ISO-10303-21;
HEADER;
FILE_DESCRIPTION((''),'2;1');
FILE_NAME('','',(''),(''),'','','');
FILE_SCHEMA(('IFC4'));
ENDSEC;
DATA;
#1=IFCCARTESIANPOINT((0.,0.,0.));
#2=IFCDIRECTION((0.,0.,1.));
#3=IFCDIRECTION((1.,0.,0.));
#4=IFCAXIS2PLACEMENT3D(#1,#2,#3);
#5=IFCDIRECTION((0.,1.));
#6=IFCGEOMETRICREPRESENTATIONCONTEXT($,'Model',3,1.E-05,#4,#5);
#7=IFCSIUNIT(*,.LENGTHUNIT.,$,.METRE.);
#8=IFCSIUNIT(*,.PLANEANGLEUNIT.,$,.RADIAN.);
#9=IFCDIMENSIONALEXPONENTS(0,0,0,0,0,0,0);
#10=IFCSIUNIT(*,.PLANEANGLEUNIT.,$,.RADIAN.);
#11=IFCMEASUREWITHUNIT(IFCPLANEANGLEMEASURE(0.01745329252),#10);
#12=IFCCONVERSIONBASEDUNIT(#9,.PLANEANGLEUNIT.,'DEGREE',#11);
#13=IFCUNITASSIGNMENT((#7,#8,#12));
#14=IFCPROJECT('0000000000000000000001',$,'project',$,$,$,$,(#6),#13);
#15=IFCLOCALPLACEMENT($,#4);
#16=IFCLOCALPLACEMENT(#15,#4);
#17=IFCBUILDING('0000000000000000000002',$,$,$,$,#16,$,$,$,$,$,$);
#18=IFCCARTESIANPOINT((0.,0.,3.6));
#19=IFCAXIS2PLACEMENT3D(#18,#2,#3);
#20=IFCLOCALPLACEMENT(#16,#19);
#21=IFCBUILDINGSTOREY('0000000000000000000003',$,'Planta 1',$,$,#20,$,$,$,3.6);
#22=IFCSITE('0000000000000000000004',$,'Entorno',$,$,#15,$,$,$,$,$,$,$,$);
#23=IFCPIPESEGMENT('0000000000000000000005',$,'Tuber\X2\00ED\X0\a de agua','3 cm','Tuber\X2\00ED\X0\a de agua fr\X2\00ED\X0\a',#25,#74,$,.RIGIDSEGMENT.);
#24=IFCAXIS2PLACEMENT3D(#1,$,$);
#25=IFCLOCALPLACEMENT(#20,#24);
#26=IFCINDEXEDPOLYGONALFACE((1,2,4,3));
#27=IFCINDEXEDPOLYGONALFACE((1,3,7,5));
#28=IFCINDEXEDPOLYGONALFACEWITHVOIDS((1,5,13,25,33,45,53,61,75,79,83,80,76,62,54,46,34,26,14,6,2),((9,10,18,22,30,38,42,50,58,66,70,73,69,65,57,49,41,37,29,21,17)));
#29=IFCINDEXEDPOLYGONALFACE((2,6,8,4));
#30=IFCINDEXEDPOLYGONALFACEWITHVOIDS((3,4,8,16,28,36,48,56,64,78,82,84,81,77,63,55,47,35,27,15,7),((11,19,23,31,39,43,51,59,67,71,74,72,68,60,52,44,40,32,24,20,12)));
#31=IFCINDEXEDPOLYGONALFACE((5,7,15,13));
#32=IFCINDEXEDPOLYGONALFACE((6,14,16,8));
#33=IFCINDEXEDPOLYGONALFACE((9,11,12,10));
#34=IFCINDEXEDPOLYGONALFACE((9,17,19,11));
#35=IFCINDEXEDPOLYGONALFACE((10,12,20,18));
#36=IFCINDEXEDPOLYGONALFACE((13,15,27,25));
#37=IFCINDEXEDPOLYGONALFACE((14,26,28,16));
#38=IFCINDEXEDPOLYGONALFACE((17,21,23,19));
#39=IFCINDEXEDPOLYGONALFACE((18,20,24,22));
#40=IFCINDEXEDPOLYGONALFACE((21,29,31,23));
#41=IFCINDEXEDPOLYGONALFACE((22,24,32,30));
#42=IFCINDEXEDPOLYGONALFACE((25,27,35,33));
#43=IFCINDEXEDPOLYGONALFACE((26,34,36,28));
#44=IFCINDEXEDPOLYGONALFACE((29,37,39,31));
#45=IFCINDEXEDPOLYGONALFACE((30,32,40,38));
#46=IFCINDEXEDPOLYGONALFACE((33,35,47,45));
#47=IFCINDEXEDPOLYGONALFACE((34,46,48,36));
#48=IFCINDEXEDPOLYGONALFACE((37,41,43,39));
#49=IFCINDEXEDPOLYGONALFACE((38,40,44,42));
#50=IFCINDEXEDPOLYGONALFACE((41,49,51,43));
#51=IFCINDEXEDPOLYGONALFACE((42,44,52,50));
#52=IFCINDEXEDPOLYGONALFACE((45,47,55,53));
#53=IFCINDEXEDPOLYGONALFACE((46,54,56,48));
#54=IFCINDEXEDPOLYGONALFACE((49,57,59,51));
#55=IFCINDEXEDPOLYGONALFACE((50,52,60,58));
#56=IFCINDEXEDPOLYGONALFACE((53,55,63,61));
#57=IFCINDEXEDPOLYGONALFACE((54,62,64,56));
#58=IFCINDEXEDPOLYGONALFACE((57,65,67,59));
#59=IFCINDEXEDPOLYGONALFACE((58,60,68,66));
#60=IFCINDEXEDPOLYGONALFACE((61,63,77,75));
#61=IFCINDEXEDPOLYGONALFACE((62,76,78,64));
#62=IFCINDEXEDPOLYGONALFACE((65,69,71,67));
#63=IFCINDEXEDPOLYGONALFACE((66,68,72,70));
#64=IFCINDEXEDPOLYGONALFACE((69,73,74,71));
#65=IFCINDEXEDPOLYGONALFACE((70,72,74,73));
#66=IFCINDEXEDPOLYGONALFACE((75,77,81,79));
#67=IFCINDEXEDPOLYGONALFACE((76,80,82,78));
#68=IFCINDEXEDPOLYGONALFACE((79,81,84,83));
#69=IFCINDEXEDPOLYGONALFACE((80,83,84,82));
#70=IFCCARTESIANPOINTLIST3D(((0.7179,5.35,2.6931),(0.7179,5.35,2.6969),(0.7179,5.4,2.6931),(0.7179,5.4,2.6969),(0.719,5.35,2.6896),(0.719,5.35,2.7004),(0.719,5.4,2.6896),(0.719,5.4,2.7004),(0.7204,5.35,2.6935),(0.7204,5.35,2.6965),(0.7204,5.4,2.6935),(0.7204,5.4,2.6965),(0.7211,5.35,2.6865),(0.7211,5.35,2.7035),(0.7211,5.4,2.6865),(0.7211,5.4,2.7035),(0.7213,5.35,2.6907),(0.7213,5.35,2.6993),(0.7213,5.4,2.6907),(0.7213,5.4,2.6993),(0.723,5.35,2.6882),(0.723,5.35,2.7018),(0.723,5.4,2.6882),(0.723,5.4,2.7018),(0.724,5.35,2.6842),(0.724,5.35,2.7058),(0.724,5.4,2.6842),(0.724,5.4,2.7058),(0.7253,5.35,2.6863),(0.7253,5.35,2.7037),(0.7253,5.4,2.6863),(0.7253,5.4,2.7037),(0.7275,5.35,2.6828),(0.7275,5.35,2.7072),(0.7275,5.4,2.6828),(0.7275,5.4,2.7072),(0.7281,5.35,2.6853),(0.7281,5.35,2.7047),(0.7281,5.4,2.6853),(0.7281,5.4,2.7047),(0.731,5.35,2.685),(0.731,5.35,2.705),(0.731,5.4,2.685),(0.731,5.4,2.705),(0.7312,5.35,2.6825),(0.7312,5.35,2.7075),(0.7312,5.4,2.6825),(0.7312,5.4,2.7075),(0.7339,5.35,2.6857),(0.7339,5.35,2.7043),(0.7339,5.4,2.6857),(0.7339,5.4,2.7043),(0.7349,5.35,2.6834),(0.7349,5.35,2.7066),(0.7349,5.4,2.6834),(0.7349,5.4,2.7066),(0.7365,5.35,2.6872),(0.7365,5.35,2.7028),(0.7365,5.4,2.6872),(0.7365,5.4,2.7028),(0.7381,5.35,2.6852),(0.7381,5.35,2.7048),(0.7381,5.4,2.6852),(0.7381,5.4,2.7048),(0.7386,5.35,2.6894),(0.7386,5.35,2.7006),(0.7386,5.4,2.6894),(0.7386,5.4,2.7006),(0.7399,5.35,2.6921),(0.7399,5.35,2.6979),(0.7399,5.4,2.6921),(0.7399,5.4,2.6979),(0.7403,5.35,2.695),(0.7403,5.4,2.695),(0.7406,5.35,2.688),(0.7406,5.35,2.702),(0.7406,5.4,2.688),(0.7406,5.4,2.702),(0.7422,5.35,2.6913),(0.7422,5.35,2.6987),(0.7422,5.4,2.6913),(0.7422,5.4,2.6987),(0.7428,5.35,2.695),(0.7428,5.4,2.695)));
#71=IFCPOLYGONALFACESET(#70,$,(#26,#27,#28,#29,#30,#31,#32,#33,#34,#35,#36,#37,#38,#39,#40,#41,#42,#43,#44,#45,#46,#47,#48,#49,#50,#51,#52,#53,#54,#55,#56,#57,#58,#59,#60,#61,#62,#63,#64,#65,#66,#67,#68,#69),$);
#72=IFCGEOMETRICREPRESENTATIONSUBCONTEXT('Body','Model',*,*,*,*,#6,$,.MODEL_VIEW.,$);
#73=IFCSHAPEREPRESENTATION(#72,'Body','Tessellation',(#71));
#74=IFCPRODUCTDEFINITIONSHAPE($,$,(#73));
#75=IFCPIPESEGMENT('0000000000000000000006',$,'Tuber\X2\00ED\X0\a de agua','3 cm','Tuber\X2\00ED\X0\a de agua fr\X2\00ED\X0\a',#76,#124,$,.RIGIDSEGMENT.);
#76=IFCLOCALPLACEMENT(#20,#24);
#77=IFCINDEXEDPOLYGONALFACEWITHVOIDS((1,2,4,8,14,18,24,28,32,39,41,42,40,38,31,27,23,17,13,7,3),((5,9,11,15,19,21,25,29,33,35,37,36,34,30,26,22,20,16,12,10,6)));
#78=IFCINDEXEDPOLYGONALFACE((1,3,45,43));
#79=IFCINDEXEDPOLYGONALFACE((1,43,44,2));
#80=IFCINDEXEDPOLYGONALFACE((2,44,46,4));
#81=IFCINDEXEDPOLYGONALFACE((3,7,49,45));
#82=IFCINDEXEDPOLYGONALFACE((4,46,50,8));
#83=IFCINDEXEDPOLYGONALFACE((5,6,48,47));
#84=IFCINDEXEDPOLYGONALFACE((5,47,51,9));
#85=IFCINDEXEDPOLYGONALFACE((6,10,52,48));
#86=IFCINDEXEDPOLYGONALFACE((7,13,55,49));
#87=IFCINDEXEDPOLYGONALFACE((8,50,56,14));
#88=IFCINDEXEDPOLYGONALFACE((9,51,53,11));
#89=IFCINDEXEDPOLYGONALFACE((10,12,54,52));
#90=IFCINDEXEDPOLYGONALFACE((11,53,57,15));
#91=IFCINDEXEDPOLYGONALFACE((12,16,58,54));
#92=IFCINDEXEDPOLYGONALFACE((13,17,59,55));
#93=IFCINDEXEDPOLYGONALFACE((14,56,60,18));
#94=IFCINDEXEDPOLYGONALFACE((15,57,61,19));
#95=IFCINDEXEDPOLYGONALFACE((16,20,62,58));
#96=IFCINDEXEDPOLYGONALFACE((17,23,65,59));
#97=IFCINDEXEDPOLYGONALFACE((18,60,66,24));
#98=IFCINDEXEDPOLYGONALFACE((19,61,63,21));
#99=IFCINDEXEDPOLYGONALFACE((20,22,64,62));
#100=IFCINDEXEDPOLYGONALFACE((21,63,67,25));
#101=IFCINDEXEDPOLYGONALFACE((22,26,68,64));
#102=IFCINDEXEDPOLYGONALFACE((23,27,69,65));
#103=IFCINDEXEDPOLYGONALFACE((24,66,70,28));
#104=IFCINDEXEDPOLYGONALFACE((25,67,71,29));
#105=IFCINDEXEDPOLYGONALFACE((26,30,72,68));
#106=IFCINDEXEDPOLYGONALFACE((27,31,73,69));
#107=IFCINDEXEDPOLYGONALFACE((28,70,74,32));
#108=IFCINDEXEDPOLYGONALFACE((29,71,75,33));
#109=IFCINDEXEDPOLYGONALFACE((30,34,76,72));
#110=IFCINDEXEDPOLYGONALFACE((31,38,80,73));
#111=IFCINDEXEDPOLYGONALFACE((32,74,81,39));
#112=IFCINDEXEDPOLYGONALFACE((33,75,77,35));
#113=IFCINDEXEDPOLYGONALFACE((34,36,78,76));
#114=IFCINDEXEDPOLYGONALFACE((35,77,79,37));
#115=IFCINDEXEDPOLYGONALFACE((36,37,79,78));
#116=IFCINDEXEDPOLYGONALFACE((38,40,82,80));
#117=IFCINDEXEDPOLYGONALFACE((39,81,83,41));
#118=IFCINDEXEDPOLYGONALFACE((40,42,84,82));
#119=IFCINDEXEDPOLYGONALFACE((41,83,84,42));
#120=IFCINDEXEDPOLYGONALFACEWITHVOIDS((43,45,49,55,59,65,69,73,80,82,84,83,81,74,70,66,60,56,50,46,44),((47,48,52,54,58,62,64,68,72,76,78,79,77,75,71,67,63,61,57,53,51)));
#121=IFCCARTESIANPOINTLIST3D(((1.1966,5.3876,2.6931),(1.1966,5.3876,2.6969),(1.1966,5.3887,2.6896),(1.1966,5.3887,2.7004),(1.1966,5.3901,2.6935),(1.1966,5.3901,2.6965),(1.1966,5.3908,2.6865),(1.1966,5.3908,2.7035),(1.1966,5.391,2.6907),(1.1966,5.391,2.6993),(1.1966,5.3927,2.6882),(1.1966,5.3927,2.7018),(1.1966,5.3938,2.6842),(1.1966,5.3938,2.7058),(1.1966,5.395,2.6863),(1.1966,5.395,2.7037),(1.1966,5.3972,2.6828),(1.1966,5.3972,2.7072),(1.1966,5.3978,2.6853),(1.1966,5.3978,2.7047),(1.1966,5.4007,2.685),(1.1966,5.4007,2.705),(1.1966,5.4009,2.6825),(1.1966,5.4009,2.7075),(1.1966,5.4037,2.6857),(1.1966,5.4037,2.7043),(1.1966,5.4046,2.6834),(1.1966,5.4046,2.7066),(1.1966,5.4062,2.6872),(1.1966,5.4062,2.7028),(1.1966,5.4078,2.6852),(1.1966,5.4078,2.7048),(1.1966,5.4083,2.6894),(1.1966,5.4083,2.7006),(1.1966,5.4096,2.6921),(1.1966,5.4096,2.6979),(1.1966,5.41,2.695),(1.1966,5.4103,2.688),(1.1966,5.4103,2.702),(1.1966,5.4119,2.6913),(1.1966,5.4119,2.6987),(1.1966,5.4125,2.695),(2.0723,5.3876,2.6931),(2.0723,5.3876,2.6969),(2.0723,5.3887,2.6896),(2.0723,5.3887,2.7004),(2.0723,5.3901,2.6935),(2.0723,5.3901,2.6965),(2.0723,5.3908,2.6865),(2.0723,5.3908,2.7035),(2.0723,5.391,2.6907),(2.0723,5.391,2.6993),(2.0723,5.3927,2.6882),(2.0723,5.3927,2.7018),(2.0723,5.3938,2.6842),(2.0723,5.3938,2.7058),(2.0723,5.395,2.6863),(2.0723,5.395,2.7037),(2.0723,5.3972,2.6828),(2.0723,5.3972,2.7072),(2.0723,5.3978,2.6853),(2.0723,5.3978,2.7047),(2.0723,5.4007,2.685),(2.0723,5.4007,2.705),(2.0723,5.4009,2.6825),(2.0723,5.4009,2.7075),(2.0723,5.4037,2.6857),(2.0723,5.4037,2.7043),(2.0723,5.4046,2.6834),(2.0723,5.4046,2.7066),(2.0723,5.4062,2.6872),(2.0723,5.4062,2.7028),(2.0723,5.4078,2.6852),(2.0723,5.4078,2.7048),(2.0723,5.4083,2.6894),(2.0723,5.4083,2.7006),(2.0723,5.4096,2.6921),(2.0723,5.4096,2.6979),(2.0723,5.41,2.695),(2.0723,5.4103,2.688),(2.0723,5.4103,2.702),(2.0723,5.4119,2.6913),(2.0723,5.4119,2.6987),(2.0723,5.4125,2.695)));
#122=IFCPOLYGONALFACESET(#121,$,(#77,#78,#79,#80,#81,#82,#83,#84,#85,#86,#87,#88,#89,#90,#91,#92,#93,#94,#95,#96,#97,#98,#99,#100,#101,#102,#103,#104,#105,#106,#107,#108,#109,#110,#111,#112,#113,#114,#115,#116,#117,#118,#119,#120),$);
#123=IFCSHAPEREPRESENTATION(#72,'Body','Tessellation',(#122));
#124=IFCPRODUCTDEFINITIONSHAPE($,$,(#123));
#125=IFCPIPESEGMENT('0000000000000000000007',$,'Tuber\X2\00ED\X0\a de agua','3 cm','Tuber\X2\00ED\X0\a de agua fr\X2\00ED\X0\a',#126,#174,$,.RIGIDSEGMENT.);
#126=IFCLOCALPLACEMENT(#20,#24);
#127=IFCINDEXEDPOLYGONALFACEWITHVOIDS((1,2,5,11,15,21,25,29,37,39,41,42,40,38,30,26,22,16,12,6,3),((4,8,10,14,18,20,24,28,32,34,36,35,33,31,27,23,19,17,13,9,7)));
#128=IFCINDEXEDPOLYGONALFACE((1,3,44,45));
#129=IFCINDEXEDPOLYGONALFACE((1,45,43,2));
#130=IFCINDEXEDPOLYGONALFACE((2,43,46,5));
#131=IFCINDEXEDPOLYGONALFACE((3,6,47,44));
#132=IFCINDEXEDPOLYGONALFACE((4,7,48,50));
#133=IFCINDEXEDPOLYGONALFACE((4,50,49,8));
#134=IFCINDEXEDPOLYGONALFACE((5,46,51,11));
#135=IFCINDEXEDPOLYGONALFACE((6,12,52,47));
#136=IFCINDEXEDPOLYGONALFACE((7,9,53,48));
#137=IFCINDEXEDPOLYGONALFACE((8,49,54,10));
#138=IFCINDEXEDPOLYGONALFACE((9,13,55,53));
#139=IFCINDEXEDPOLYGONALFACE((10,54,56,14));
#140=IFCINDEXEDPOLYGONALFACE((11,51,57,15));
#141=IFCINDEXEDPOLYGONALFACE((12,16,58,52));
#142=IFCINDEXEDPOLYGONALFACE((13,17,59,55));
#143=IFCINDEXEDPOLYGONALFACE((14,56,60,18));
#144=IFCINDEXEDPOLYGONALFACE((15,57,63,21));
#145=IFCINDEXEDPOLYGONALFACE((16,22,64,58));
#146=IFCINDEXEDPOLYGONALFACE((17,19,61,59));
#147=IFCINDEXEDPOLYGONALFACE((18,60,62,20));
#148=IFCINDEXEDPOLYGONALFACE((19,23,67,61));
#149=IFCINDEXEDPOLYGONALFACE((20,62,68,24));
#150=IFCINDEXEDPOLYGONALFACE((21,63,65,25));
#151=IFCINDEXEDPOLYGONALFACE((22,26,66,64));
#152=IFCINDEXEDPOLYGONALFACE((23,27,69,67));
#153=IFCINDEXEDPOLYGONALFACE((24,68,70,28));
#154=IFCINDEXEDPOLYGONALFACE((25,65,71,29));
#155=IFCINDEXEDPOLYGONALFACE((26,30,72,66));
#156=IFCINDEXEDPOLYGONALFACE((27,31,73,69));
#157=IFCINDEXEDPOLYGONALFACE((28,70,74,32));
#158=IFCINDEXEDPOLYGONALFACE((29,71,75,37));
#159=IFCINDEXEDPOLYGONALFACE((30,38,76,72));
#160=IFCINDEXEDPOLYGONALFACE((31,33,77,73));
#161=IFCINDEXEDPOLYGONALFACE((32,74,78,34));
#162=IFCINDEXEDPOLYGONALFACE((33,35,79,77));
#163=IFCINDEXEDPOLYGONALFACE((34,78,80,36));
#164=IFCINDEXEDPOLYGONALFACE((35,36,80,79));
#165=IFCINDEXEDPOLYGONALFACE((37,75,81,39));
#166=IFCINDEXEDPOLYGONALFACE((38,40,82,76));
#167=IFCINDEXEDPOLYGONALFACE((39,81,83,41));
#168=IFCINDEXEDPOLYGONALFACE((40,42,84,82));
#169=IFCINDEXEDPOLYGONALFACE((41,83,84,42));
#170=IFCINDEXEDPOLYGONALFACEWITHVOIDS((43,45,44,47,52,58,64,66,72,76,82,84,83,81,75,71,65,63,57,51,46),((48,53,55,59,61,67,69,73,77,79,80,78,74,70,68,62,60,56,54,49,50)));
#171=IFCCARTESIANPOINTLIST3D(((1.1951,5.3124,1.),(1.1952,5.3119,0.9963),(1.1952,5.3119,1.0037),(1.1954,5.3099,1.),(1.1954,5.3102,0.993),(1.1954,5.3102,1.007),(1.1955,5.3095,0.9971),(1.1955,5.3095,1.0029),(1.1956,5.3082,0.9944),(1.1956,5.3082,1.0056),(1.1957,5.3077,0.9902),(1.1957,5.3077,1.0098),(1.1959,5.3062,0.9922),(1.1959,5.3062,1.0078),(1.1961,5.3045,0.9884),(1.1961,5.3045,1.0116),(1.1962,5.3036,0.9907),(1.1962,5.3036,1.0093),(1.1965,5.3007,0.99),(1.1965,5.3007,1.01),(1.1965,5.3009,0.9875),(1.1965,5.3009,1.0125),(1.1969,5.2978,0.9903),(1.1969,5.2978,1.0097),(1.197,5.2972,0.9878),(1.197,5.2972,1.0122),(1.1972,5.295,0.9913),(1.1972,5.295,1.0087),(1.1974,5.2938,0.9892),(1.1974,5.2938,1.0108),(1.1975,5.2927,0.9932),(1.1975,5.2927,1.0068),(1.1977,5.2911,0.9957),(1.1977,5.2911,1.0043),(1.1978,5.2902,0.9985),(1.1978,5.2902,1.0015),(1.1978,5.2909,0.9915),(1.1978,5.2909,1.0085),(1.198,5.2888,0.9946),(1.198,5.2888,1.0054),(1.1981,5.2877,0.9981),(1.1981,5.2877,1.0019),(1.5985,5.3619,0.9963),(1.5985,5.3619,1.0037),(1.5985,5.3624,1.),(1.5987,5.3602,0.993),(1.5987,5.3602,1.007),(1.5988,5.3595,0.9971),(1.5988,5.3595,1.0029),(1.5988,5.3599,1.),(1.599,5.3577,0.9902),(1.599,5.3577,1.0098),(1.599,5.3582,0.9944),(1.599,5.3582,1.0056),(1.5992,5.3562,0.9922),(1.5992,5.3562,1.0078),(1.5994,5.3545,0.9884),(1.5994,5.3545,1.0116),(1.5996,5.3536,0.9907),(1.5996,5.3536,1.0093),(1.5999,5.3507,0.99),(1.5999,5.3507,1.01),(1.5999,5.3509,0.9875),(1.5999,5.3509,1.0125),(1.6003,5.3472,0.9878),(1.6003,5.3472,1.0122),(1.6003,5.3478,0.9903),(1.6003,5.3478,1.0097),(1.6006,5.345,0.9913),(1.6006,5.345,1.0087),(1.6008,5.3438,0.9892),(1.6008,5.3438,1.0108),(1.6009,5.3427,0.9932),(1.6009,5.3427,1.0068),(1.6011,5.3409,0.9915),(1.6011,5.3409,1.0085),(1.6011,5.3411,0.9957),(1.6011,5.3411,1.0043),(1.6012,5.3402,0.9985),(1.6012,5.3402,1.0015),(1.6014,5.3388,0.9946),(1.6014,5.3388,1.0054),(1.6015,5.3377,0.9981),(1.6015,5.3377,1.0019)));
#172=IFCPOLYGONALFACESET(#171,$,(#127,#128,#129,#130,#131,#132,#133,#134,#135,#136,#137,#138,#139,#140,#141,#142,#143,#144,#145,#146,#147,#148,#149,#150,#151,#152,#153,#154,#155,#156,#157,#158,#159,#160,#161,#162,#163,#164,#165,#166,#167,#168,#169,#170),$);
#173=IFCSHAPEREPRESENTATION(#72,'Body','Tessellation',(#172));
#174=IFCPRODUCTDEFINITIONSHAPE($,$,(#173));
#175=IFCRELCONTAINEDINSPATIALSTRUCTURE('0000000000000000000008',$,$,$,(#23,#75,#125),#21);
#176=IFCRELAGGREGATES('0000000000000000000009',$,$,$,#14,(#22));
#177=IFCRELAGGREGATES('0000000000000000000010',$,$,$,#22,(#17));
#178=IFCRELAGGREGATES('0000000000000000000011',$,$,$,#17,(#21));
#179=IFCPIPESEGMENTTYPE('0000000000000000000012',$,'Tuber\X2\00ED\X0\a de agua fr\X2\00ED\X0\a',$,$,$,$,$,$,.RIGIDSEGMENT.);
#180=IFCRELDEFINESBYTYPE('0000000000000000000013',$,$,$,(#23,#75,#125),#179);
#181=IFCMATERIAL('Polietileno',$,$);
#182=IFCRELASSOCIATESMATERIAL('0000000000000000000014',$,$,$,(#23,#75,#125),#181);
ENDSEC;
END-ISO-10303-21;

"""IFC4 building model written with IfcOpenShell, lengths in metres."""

from ifc_helpers import new_model, entity, si_unit, converted_unit, direction, frame, origin_with_axes, origin_2d_with_axis, place, context, subcontext, project, spatial, hollow_circle, extrude, material, type_object, element, save


model = new_model("IFC4")

# Units and contexts
model_context = context("Model", 3, precision=1e-05, world=origin_with_axes(), true_north=direction((0.0, 1.0)))
body_context = subcontext(model_context, "Body", "Model", "MODEL_VIEW")
ifc_project = project(units=[si_unit("LENGTHUNIT", "METRE"), si_unit("PLANEANGLEUNIT", "RADIAN"), converted_unit("PLANEANGLEUNIT", "DEGREE", entity("IfcPlaneAngleMeasure", 0.01745329252), si_unit("PLANEANGLEUNIT", "RADIAN"), dimensions=[0, 0, 0, 0, 0, 0, 0])], contexts=[model_context])

# Site, building, storey
site_placement = place(None, origin_with_axes())
site = spatial("IfcSite", under=ifc_project, at=site_placement, Name="Entorno")
building_placement = place(site_placement, origin_with_axes())
building = spatial("IfcBuilding", under=site, at=building_placement)
storey_placement = place(building_placement, frame((0.0, 0.0, 3.6), z_axis=(0.0, 0.0, 1.0), x_axis=(1.0, 0.0, 0.0)))
storey = spatial("IfcBuildingStorey", under=building, at=storey_placement, Name="Planta 1", Elevation=3.6)

# Pipe segments
ifc_material_1 = material(Name="Polietileno")
pipe_segment_type_1 = type_object("IfcPipeSegmentType", Name="Tubería de agua fría", PredefinedType="RIGIDSEGMENT")
pipe_segment_1_placement = place(storey_placement, frame((0.7303, 5.4, 2.695), z_axis=(0.0, -1.0, 0.0), x_axis=(1.0, 0.0, 0.0)))
element("IfcPipeSegment", 1, at=pipe_segment_1_placement, inside=storey, type_object=pipe_segment_type_1, material=ifc_material_1, Name="Tubería de agua", Description="3 cm", ObjectType="Tubería de agua fría", PredefinedType="RIGIDSEGMENT", context=body_context, shape_type="SweptSolid", body=[
    extrude(hollow_circle(Radius=0.0125, WallThickness=0.0025, at=origin_2d_with_axis()), origin_with_axes(), (0.0, 0.0, 1.0), 0.05),
])
pipe_segment_2_placement = place(storey_placement, frame((1.1966, 5.4, 2.695), z_axis=(1.0, 0.0, 0.0), x_axis=(0.0, 1.0, 0.0)))
element("IfcPipeSegment", 2, at=pipe_segment_2_placement, inside=storey, type_object=pipe_segment_type_1, material=ifc_material_1, Name="Tubería de agua", Description="3 cm", ObjectType="Tubería de agua fría", PredefinedType="RIGIDSEGMENT", context=body_context, shape_type="SweptSolid", body=[
    extrude(hollow_circle(Radius=0.0125, WallThickness=0.0025, at=origin_2d_with_axis()), origin_with_axes(), (0.0, 0.0, 1.0), 0.8757),
])
pipe_segment_3_placement = place(storey_placement, frame((1.1966, 5.3, 1.0), z_axis=(0.992405, 0.123014, 0.0), x_axis=(-0.123014, 0.992405, 0.0)))
element("IfcPipeSegment", 3, at=pipe_segment_3_placement, inside=storey, type_object=pipe_segment_type_1, material=ifc_material_1, Name="Tubería de agua", Description="3 cm", ObjectType="Tubería de agua fría", PredefinedType="RIGIDSEGMENT", context=body_context, shape_type="SweptSolid", body=[
    extrude(hollow_circle(Radius=0.0125, WallThickness=0.0025, at=origin_2d_with_axis()), origin_with_axes(), (0.0, 0.0, 1.0), 0.4065),
])

save(model, "model.ifc")
